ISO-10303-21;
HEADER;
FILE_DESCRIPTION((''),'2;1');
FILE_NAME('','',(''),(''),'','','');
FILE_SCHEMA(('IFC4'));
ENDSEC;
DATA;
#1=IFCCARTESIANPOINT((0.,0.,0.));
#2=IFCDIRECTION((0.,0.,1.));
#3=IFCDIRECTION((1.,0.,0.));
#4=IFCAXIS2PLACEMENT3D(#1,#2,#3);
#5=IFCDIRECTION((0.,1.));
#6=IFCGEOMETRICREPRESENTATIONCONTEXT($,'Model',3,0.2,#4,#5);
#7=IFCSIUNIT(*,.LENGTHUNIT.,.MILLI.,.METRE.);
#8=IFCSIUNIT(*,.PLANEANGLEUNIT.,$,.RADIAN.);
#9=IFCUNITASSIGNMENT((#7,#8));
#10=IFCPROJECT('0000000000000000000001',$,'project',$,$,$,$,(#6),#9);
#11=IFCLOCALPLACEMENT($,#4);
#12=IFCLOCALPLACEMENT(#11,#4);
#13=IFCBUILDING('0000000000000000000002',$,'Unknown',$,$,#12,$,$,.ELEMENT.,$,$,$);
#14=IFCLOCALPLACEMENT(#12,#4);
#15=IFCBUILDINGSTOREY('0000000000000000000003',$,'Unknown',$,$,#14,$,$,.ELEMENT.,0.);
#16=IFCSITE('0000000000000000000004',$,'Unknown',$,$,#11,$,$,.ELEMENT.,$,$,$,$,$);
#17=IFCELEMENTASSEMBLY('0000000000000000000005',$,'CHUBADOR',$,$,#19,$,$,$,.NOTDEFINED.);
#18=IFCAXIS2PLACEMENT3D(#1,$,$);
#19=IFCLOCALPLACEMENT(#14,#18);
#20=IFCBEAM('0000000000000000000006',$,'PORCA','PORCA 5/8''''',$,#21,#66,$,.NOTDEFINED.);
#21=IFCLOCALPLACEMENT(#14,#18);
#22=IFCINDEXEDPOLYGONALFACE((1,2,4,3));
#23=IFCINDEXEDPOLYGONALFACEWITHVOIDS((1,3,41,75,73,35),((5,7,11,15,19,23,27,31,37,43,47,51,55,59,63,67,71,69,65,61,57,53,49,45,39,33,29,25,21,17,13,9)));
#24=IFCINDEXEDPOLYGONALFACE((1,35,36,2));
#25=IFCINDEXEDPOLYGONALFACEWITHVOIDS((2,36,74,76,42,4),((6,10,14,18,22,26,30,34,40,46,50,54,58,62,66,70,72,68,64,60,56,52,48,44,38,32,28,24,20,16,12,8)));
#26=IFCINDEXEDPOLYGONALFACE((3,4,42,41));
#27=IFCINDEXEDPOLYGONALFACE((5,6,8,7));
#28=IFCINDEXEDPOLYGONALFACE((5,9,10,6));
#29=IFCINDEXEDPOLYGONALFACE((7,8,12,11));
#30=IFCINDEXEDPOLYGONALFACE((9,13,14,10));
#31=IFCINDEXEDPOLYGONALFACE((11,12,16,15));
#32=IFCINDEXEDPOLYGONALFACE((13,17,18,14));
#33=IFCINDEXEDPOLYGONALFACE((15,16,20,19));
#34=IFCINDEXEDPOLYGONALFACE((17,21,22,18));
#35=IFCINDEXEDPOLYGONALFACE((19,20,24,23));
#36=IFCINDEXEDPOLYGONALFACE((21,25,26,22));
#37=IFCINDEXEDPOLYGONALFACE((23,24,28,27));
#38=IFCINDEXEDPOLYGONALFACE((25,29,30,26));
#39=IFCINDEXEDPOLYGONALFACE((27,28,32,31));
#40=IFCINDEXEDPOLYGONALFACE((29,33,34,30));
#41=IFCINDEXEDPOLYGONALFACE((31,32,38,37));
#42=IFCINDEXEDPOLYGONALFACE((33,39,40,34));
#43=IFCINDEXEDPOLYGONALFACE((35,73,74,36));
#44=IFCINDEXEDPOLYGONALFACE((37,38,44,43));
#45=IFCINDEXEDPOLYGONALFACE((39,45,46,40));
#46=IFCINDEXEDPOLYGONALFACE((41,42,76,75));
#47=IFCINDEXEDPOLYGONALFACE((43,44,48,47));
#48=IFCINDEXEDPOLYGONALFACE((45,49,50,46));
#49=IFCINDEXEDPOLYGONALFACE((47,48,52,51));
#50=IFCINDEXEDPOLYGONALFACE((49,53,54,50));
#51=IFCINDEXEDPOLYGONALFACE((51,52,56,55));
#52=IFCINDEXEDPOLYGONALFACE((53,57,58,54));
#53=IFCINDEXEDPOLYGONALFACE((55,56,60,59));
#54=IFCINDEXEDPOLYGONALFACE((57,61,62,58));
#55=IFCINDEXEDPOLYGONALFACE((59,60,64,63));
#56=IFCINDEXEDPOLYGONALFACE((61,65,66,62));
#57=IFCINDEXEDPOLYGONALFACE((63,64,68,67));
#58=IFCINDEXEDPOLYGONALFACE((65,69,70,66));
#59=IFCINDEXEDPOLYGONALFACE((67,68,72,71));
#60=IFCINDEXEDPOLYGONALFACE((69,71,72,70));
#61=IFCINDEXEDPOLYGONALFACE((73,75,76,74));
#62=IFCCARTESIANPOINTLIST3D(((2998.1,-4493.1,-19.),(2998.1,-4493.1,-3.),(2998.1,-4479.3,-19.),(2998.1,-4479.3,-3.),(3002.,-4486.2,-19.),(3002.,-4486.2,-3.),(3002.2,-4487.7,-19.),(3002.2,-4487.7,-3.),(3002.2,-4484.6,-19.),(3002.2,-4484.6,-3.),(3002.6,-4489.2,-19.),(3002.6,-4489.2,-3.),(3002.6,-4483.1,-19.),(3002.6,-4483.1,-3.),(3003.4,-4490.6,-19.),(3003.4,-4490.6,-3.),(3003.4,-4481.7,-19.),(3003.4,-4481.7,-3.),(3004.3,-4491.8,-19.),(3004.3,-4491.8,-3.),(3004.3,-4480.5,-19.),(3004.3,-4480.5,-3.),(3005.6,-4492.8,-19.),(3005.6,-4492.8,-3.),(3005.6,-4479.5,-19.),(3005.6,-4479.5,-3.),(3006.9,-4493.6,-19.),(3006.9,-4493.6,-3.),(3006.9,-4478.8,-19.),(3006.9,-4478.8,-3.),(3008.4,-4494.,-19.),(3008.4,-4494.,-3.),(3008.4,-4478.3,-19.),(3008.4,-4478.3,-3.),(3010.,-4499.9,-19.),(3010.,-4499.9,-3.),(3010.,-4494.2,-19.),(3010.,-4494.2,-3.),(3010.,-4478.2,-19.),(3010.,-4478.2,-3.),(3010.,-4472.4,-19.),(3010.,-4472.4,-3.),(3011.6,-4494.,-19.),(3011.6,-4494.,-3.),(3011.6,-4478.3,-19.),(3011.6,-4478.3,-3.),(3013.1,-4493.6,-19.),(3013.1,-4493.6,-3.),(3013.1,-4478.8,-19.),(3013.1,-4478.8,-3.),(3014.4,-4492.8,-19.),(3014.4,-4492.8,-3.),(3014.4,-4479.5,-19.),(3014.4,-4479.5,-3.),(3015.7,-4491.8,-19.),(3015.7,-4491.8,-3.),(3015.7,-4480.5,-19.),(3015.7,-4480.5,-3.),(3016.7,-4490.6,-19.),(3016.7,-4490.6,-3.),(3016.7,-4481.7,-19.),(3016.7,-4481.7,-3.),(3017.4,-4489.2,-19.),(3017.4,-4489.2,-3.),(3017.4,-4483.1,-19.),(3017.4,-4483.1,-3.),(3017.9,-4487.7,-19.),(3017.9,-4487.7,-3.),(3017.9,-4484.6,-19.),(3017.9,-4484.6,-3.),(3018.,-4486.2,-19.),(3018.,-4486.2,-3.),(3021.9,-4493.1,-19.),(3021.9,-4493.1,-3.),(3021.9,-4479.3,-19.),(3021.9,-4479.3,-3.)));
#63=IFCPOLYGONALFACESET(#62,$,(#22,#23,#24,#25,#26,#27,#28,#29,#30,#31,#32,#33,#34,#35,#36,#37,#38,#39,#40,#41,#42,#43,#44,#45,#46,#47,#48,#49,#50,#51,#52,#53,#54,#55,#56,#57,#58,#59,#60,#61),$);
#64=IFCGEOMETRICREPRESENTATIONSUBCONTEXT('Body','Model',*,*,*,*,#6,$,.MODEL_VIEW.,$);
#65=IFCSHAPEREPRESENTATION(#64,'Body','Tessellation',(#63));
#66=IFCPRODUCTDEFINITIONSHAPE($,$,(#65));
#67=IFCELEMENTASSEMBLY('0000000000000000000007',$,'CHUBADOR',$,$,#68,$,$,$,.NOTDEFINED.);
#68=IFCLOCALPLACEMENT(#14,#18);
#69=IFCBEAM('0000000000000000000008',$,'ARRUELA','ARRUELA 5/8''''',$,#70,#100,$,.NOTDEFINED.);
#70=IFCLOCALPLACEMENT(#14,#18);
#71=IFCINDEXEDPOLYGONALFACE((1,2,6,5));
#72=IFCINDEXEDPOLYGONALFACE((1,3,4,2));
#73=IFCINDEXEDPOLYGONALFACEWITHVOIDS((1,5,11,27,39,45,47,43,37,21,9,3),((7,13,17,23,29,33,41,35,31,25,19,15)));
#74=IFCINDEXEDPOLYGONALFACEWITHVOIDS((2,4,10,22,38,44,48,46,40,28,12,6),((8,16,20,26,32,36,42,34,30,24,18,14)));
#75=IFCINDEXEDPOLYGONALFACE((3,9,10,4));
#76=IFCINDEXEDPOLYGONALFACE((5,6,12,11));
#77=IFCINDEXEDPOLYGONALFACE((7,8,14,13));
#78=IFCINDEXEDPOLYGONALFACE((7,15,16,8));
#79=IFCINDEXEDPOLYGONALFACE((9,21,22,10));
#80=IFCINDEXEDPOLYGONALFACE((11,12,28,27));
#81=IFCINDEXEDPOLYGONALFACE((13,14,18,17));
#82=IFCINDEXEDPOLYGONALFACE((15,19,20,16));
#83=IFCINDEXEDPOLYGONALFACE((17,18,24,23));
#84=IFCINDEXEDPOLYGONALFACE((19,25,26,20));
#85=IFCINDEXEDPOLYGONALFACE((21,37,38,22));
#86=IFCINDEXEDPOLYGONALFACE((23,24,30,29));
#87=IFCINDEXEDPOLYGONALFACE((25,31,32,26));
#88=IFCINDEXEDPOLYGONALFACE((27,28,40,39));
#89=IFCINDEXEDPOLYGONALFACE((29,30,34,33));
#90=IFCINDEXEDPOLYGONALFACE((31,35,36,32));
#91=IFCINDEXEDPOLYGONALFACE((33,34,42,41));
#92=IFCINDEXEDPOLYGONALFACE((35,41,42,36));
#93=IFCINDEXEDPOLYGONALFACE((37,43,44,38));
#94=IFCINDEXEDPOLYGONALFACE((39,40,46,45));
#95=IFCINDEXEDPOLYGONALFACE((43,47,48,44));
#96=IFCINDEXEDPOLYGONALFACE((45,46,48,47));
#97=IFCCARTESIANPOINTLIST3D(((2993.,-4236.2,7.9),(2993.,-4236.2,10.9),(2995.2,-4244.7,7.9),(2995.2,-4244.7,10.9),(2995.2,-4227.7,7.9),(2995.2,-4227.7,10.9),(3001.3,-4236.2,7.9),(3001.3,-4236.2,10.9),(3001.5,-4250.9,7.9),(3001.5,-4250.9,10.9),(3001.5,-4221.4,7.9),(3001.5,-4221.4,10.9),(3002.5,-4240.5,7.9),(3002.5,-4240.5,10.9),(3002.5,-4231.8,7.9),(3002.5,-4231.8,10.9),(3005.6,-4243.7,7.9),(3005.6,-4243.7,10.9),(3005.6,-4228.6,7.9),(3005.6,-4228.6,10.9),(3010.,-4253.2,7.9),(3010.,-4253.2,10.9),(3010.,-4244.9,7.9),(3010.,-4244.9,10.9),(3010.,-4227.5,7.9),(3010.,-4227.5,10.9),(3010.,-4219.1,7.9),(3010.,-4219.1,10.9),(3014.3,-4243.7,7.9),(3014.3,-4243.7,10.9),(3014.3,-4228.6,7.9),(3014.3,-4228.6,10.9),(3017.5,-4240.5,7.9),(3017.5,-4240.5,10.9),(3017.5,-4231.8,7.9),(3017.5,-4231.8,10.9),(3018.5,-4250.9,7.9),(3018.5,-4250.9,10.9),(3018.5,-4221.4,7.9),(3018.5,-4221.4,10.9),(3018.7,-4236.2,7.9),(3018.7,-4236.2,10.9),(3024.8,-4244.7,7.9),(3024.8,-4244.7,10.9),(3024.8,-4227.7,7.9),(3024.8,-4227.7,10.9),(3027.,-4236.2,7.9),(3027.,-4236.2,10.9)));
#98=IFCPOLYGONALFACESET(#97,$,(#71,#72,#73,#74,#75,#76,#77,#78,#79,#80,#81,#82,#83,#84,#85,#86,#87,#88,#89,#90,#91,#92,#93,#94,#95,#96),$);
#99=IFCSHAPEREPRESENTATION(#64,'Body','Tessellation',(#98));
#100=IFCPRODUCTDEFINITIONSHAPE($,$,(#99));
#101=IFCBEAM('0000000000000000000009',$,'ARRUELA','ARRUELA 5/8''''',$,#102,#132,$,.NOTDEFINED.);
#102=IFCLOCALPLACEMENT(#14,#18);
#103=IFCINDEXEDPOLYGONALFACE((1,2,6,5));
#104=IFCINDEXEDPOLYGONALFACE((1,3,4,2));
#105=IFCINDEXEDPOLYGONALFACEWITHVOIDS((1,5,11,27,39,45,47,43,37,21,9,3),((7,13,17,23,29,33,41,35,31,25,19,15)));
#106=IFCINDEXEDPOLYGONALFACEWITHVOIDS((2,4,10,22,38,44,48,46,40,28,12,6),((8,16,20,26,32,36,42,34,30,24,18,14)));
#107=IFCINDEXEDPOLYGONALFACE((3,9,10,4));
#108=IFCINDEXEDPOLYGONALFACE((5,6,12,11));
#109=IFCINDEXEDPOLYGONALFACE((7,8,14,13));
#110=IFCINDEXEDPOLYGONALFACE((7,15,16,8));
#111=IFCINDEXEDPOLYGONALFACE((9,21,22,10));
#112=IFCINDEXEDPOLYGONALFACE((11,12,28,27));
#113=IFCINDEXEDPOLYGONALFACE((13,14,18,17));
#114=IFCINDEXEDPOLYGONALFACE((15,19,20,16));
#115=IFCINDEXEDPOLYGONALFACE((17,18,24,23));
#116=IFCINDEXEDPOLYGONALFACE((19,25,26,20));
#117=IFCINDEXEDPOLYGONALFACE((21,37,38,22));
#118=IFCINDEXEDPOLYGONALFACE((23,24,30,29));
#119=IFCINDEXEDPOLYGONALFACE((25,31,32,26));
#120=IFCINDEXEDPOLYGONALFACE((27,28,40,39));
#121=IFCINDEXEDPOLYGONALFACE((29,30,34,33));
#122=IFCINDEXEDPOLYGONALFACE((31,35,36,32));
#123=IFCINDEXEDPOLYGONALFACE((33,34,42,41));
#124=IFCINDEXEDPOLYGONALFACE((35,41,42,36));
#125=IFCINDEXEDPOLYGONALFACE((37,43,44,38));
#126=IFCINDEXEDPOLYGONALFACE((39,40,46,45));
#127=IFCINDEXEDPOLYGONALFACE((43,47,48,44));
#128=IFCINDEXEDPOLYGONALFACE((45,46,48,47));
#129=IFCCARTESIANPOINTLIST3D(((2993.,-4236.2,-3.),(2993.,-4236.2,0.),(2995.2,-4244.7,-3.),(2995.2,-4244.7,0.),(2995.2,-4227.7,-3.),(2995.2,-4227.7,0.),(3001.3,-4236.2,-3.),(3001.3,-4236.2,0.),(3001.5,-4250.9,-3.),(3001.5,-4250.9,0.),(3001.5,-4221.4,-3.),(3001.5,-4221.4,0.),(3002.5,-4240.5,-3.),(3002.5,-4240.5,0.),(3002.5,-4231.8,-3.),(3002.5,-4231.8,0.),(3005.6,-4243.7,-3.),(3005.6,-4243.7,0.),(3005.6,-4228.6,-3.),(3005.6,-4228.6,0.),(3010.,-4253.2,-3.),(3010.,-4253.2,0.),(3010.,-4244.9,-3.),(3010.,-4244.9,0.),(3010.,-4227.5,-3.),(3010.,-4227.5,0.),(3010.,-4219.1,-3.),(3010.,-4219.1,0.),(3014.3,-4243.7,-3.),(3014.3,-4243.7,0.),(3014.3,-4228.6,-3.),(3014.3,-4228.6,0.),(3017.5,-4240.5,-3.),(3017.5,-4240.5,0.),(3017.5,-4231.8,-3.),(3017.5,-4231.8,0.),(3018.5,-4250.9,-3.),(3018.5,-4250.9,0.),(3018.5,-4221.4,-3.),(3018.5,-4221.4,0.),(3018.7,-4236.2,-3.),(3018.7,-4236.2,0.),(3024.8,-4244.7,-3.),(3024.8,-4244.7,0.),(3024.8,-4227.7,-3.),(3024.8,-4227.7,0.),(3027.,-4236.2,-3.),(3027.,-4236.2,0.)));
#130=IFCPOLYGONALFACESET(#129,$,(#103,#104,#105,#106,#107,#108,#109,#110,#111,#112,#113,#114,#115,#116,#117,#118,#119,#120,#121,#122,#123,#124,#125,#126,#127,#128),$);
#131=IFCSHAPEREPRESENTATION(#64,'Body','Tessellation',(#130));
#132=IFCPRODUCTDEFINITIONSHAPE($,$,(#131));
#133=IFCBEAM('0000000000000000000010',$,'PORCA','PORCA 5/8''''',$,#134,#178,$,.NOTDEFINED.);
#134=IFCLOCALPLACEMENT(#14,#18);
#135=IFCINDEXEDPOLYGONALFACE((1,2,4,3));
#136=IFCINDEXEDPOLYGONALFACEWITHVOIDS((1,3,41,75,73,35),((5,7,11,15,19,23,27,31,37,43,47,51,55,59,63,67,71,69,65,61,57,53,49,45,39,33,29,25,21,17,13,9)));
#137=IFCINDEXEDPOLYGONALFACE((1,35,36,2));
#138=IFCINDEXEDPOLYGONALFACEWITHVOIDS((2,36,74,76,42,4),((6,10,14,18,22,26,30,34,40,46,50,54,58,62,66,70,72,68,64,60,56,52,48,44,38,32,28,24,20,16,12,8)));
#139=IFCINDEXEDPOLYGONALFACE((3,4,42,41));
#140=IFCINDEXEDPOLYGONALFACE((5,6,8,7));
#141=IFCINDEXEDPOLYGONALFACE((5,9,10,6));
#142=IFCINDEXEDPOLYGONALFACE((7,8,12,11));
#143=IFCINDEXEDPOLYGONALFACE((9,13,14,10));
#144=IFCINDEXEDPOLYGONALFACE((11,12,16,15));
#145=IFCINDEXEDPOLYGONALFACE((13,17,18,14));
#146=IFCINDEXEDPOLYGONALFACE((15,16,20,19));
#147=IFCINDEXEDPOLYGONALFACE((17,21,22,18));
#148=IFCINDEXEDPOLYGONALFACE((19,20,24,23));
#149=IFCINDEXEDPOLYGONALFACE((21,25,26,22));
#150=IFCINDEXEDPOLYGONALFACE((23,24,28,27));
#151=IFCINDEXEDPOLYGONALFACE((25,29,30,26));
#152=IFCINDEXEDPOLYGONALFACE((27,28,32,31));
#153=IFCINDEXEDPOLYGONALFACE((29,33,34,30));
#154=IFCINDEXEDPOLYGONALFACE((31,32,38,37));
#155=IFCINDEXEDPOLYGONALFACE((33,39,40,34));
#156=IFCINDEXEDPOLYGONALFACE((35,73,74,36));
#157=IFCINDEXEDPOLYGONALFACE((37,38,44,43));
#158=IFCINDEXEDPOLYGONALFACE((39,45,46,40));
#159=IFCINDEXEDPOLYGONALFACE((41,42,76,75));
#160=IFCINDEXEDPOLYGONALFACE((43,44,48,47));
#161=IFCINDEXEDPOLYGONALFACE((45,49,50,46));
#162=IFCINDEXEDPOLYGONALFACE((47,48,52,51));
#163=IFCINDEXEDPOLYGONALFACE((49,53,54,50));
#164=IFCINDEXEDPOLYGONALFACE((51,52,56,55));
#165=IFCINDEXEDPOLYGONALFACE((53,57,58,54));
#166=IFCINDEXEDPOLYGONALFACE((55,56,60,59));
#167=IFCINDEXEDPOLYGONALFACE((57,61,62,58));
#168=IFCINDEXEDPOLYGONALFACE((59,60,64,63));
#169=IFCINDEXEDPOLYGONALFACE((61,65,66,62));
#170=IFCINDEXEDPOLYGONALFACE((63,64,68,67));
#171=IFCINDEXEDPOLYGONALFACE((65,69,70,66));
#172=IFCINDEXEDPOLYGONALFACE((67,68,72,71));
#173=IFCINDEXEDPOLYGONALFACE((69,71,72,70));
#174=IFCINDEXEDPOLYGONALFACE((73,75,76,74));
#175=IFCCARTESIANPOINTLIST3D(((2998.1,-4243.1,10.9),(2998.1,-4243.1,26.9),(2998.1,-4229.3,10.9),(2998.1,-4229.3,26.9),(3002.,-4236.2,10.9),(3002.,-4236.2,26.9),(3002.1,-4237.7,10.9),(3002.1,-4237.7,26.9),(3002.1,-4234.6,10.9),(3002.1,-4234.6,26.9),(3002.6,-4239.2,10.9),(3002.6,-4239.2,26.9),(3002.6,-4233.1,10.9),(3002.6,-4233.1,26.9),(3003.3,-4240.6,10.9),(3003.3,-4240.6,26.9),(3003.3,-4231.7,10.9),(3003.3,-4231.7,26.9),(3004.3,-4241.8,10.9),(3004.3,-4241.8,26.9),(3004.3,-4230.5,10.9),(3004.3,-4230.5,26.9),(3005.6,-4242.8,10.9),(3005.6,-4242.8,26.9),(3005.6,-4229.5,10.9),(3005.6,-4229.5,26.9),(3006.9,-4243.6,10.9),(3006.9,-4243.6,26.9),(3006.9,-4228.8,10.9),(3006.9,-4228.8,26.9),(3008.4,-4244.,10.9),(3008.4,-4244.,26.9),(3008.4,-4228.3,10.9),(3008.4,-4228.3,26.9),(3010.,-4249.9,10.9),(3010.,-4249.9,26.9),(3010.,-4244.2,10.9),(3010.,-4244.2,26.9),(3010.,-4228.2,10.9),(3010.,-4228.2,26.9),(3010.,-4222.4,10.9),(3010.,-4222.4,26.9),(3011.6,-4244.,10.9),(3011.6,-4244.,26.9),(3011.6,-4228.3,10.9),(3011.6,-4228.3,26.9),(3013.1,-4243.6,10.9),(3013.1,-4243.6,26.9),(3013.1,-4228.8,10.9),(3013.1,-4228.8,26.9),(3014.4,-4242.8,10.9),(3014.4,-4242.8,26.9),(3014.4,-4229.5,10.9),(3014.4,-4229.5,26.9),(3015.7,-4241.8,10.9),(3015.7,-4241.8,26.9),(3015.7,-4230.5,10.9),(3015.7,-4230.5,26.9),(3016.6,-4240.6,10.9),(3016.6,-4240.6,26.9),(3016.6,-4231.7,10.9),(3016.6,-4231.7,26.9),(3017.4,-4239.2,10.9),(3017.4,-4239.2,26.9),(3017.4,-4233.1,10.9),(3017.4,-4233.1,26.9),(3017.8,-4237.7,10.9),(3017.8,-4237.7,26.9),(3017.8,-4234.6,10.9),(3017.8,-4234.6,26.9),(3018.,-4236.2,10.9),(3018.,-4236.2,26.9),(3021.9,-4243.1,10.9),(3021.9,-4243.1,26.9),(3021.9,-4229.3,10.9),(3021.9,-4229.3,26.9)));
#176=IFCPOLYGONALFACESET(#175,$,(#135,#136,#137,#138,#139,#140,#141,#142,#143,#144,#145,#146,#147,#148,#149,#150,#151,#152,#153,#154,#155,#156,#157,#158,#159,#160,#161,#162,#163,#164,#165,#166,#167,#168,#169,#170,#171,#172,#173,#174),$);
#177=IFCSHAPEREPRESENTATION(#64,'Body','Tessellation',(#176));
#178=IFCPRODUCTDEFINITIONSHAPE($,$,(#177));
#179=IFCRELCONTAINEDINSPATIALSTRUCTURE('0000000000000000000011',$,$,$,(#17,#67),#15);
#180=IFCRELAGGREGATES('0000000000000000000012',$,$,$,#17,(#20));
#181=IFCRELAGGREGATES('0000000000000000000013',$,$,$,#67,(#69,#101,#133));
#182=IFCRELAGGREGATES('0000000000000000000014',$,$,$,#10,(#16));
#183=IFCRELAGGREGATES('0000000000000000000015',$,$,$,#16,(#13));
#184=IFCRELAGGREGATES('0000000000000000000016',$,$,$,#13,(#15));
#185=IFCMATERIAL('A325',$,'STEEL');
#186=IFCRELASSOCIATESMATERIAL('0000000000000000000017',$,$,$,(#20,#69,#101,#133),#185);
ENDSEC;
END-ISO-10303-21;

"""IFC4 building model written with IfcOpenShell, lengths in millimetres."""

from ifc_helpers import new_model, si_unit, direction, frame, origin_with_axes, place, context, subcontext, project, spatial, line, indexed_curve, outline, extrude, material, element, aggregate, save


model = new_model("IFC4")

# Units and contexts
model_context = context("Model", 3, precision=0.2, world=origin_with_axes(), true_north=direction((0.0, 1.0)))
body_context = subcontext(model_context, "Body", "Model", "MODEL_VIEW")
ifc_project = project(units=[si_unit("LENGTHUNIT", "METRE", prefix="MILLI"), si_unit("PLANEANGLEUNIT", "RADIAN")], contexts=[model_context])

# Site, building, storey
site_placement = place(None, origin_with_axes())
site = spatial("IfcSite", under=ifc_project, at=site_placement, Name="Unknown", CompositionType="ELEMENT")
building_placement = place(site_placement, origin_with_axes())
building = spatial("IfcBuilding", under=site, at=building_placement, Name="Unknown", CompositionType="ELEMENT")
storey_placement = place(building_placement, origin_with_axes())
storey = spatial("IfcBuildingStorey", under=building, at=storey_placement, Name="Unknown", CompositionType="ELEMENT", Elevation=0.0)

# Element assemblies, beams
ifc_material_1 = material(Name="A325", Category="STEEL")
assembly_1_placement = place(storey_placement, frame((3010.0, -4486.2, -44.2), z_axis=(-1.0, 0.0, 0.0), x_axis=(0.0, 0.0, -1.0)))
assembly_1 = element("IfcElementAssembly", 1, at=assembly_1_placement, inside=storey, Name="CHUBADOR", PredefinedType="NOTDEFINED")
beam_1_placement = place(assembly_1_placement, frame((-41.2, 0.0, 0.0), z_axis=(0.0, 0.0, 1.0), x_axis=(1.0, 0.0, 0.0)))
beam_1 = element("IfcBeam", 2, at=beam_1_placement, material=ifc_material_1, Name="PORCA", Description="PORCA 5/8''", PredefinedType="NOTDEFINED", context=body_context, shape_type="SolidModel", body=[
    extrude(outline(indexed_curve([(0.0, 13.8), (-11.9, 6.9), (-11.9, -6.9), (0.0, -13.8), (11.9, -6.9), (11.9, 6.9)], segments=[line(1, 2, 3, 4, 5, 6, 1)]), holes=[indexed_curve([(7.8, 1.6), (8.0, 0.0), (7.8, -1.6), (7.4, -3.1), (6.7, -4.4), (5.7, -5.7), (4.4, -6.7), (3.1, -7.4), (1.6, -7.8), (0.0, -8.0), (-1.6, -7.8), (-3.1, -7.4), (-4.4, -6.7), (-5.7, -5.7), (-6.7, -4.4), (-7.4, -3.1), (-7.8, -1.6), (-8.0, 0.0), (-7.8, 1.6), (-7.4, 3.1), (-6.7, 4.4), (-5.7, 5.7), (-4.4, 6.7), (-3.1, 7.4), (-1.6, 7.8), (0.0, 8.0), (1.6, 7.8), (3.1, 7.4), (4.4, 6.7), (5.7, 5.7), (6.7, 4.4), (7.4, 3.1)], segments=[line(1, 2, 3, 4, 5, 6, 7, 8, 9, 10, 11, 12, 13, 14, 15, 16, 17, 18, 19, 20, 21, 22, 23, 24, 25, 26, 27, 28, 29, 30, 31, 32, 1)])]), frame((0.0, 0.0, 0.0), z_axis=(-1.0, 0.0, 0.0), x_axis=(0.0, 0.0, 1.0)), (0.0, 0.0, -1.0), 16.0),
])
aggregate(assembly_1, [beam_1])
assembly_2_placement = place(storey_placement, frame((3010.0, -4236.2, -52.1), z_axis=(-1.0, 0.0, 0.0), x_axis=(0.0, 0.0, -1.0)))
assembly_2 = element("IfcElementAssembly", 3, at=assembly_2_placement, inside=storey, Name="CHUBADOR", PredefinedType="NOTDEFINED")
beam_2_placement = place(assembly_2_placement, frame((-63.0, 0.0, 0.0), z_axis=(0.0, 0.0, 1.0), x_axis=(1.0, 0.0, 0.0)))
beam_2 = element("IfcBeam", 4, at=beam_2_placement, material=ifc_material_1, Name="ARRUELA", Description="ARRUELA 5/8''", PredefinedType="NOTDEFINED", context=body_context, shape_type="SolidModel", body=[
    extrude(outline(indexed_curve([(17.0, 0.0), (14.8, 8.5), (8.5, 14.8), (0.0, 17.0), (-8.5, 14.8), (-14.8, 8.5), (-17.0, 0.0), (-14.8, -8.5), (-8.5, -14.8), (0.0, -17.0), (8.5, -14.8), (14.8, -8.5)], segments=[line(1, 2, 3, 4, 5, 6, 7, 8, 9, 10, 11, 12, 1)]), holes=[indexed_curve([(8.7, 0.0), (7.5, -4.3), (4.3, -7.5), (0.0, -8.7), (-4.3, -7.5), (-7.5, -4.3), (-8.7, 0.0), (-7.5, 4.3), (-4.3, 7.5), (0.0, 8.7), (4.3, 7.5), (7.5, 4.3)], segments=[line(1, 2, 3, 4, 5, 6, 7, 8, 9, 10, 11, 12, 1)])]), frame((0.0, 0.0, 0.0), z_axis=(-1.0, 0.0, 0.0), x_axis=(0.0, 0.0, 1.0)), (0.0, 0.0, -1.0), 3.0),
])
beam_3_placement = place(assembly_2_placement, frame((-52.1, 0.0, 0.0), z_axis=(0.0, 0.0, 1.0), x_axis=(1.0, 0.0, 0.0)))
beam_3 = element("IfcBeam", 5, at=beam_3_placement, material=ifc_material_1, Name="ARRUELA", Description="ARRUELA 5/8''", PredefinedType="NOTDEFINED", context=body_context, shape_type="SolidModel", body=[
    extrude(outline(indexed_curve([(17.0, 0.0), (14.8, 8.5), (8.5, 14.8), (0.0, 17.0), (-8.5, 14.8), (-14.8, 8.5), (-17.0, 0.0), (-14.8, -8.5), (-8.5, -14.8), (0.0, -17.0), (8.5, -14.8), (14.8, -8.5)], segments=[line(1, 2, 3, 4, 5, 6, 7, 8, 9, 10, 11, 12, 1)]), holes=[indexed_curve([(8.7, 0.0), (7.5, -4.3), (4.3, -7.5), (0.0, -8.7), (-4.3, -7.5), (-7.5, -4.3), (-8.7, 0.0), (-7.5, 4.3), (-4.3, 7.5), (0.0, 8.7), (4.3, 7.5), (7.5, 4.3)], segments=[line(1, 2, 3, 4, 5, 6, 7, 8, 9, 10, 11, 12, 1)])]), frame((0.0, 0.0, 0.0), z_axis=(-1.0, 0.0, 0.0), x_axis=(0.0, 0.0, 1.0)), (0.0, 0.0, -1.0), 3.0),
])
beam_4_placement = place(assembly_2_placement, frame((-79.0, 0.0, 0.0), z_axis=(0.0, 0.0, 1.0), x_axis=(1.0, 0.0, 0.0)))
beam_4 = element("IfcBeam", 6, at=beam_4_placement, material=ifc_material_1, Name="PORCA", Description="PORCA 5/8''", PredefinedType="NOTDEFINED", context=body_context, shape_type="SolidModel", body=[
    extrude(outline(indexed_curve([(0.0, 13.8), (-11.9, 6.9), (-11.9, -6.9), (0.0, -13.8), (11.9, -6.9), (11.9, 6.9)], segments=[line(1, 2, 3, 4, 5, 6, 1)]), holes=[indexed_curve([(7.8, 1.6), (8.0, 0.0), (7.8, -1.6), (7.4, -3.1), (6.7, -4.4), (5.7, -5.7), (4.4, -6.7), (3.1, -7.4), (1.6, -7.8), (0.0, -8.0), (-1.6, -7.8), (-3.1, -7.4), (-4.4, -6.7), (-5.7, -5.7), (-6.7, -4.4), (-7.4, -3.1), (-7.8, -1.6), (-8.0, 0.0), (-7.8, 1.6), (-7.4, 3.1), (-6.7, 4.4), (-5.7, 5.7), (-4.4, 6.7), (-3.1, 7.4), (-1.6, 7.8), (0.0, 8.0), (1.6, 7.8), (3.1, 7.4), (4.4, 6.7), (5.7, 5.7), (6.7, 4.4), (7.4, 3.1)], segments=[line(1, 2, 3, 4, 5, 6, 7, 8, 9, 10, 11, 12, 13, 14, 15, 16, 17, 18, 19, 20, 21, 22, 23, 24, 25, 26, 27, 28, 29, 30, 31, 32, 1)])]), frame((0.0, 0.0, 0.0), z_axis=(-1.0, 0.0, 0.0), x_axis=(0.0, 0.0, 1.0)), (0.0, 0.0, -1.0), 16.0),
])
aggregate(assembly_2, [beam_2, beam_3, beam_4])

save(model, "model.ifc")
